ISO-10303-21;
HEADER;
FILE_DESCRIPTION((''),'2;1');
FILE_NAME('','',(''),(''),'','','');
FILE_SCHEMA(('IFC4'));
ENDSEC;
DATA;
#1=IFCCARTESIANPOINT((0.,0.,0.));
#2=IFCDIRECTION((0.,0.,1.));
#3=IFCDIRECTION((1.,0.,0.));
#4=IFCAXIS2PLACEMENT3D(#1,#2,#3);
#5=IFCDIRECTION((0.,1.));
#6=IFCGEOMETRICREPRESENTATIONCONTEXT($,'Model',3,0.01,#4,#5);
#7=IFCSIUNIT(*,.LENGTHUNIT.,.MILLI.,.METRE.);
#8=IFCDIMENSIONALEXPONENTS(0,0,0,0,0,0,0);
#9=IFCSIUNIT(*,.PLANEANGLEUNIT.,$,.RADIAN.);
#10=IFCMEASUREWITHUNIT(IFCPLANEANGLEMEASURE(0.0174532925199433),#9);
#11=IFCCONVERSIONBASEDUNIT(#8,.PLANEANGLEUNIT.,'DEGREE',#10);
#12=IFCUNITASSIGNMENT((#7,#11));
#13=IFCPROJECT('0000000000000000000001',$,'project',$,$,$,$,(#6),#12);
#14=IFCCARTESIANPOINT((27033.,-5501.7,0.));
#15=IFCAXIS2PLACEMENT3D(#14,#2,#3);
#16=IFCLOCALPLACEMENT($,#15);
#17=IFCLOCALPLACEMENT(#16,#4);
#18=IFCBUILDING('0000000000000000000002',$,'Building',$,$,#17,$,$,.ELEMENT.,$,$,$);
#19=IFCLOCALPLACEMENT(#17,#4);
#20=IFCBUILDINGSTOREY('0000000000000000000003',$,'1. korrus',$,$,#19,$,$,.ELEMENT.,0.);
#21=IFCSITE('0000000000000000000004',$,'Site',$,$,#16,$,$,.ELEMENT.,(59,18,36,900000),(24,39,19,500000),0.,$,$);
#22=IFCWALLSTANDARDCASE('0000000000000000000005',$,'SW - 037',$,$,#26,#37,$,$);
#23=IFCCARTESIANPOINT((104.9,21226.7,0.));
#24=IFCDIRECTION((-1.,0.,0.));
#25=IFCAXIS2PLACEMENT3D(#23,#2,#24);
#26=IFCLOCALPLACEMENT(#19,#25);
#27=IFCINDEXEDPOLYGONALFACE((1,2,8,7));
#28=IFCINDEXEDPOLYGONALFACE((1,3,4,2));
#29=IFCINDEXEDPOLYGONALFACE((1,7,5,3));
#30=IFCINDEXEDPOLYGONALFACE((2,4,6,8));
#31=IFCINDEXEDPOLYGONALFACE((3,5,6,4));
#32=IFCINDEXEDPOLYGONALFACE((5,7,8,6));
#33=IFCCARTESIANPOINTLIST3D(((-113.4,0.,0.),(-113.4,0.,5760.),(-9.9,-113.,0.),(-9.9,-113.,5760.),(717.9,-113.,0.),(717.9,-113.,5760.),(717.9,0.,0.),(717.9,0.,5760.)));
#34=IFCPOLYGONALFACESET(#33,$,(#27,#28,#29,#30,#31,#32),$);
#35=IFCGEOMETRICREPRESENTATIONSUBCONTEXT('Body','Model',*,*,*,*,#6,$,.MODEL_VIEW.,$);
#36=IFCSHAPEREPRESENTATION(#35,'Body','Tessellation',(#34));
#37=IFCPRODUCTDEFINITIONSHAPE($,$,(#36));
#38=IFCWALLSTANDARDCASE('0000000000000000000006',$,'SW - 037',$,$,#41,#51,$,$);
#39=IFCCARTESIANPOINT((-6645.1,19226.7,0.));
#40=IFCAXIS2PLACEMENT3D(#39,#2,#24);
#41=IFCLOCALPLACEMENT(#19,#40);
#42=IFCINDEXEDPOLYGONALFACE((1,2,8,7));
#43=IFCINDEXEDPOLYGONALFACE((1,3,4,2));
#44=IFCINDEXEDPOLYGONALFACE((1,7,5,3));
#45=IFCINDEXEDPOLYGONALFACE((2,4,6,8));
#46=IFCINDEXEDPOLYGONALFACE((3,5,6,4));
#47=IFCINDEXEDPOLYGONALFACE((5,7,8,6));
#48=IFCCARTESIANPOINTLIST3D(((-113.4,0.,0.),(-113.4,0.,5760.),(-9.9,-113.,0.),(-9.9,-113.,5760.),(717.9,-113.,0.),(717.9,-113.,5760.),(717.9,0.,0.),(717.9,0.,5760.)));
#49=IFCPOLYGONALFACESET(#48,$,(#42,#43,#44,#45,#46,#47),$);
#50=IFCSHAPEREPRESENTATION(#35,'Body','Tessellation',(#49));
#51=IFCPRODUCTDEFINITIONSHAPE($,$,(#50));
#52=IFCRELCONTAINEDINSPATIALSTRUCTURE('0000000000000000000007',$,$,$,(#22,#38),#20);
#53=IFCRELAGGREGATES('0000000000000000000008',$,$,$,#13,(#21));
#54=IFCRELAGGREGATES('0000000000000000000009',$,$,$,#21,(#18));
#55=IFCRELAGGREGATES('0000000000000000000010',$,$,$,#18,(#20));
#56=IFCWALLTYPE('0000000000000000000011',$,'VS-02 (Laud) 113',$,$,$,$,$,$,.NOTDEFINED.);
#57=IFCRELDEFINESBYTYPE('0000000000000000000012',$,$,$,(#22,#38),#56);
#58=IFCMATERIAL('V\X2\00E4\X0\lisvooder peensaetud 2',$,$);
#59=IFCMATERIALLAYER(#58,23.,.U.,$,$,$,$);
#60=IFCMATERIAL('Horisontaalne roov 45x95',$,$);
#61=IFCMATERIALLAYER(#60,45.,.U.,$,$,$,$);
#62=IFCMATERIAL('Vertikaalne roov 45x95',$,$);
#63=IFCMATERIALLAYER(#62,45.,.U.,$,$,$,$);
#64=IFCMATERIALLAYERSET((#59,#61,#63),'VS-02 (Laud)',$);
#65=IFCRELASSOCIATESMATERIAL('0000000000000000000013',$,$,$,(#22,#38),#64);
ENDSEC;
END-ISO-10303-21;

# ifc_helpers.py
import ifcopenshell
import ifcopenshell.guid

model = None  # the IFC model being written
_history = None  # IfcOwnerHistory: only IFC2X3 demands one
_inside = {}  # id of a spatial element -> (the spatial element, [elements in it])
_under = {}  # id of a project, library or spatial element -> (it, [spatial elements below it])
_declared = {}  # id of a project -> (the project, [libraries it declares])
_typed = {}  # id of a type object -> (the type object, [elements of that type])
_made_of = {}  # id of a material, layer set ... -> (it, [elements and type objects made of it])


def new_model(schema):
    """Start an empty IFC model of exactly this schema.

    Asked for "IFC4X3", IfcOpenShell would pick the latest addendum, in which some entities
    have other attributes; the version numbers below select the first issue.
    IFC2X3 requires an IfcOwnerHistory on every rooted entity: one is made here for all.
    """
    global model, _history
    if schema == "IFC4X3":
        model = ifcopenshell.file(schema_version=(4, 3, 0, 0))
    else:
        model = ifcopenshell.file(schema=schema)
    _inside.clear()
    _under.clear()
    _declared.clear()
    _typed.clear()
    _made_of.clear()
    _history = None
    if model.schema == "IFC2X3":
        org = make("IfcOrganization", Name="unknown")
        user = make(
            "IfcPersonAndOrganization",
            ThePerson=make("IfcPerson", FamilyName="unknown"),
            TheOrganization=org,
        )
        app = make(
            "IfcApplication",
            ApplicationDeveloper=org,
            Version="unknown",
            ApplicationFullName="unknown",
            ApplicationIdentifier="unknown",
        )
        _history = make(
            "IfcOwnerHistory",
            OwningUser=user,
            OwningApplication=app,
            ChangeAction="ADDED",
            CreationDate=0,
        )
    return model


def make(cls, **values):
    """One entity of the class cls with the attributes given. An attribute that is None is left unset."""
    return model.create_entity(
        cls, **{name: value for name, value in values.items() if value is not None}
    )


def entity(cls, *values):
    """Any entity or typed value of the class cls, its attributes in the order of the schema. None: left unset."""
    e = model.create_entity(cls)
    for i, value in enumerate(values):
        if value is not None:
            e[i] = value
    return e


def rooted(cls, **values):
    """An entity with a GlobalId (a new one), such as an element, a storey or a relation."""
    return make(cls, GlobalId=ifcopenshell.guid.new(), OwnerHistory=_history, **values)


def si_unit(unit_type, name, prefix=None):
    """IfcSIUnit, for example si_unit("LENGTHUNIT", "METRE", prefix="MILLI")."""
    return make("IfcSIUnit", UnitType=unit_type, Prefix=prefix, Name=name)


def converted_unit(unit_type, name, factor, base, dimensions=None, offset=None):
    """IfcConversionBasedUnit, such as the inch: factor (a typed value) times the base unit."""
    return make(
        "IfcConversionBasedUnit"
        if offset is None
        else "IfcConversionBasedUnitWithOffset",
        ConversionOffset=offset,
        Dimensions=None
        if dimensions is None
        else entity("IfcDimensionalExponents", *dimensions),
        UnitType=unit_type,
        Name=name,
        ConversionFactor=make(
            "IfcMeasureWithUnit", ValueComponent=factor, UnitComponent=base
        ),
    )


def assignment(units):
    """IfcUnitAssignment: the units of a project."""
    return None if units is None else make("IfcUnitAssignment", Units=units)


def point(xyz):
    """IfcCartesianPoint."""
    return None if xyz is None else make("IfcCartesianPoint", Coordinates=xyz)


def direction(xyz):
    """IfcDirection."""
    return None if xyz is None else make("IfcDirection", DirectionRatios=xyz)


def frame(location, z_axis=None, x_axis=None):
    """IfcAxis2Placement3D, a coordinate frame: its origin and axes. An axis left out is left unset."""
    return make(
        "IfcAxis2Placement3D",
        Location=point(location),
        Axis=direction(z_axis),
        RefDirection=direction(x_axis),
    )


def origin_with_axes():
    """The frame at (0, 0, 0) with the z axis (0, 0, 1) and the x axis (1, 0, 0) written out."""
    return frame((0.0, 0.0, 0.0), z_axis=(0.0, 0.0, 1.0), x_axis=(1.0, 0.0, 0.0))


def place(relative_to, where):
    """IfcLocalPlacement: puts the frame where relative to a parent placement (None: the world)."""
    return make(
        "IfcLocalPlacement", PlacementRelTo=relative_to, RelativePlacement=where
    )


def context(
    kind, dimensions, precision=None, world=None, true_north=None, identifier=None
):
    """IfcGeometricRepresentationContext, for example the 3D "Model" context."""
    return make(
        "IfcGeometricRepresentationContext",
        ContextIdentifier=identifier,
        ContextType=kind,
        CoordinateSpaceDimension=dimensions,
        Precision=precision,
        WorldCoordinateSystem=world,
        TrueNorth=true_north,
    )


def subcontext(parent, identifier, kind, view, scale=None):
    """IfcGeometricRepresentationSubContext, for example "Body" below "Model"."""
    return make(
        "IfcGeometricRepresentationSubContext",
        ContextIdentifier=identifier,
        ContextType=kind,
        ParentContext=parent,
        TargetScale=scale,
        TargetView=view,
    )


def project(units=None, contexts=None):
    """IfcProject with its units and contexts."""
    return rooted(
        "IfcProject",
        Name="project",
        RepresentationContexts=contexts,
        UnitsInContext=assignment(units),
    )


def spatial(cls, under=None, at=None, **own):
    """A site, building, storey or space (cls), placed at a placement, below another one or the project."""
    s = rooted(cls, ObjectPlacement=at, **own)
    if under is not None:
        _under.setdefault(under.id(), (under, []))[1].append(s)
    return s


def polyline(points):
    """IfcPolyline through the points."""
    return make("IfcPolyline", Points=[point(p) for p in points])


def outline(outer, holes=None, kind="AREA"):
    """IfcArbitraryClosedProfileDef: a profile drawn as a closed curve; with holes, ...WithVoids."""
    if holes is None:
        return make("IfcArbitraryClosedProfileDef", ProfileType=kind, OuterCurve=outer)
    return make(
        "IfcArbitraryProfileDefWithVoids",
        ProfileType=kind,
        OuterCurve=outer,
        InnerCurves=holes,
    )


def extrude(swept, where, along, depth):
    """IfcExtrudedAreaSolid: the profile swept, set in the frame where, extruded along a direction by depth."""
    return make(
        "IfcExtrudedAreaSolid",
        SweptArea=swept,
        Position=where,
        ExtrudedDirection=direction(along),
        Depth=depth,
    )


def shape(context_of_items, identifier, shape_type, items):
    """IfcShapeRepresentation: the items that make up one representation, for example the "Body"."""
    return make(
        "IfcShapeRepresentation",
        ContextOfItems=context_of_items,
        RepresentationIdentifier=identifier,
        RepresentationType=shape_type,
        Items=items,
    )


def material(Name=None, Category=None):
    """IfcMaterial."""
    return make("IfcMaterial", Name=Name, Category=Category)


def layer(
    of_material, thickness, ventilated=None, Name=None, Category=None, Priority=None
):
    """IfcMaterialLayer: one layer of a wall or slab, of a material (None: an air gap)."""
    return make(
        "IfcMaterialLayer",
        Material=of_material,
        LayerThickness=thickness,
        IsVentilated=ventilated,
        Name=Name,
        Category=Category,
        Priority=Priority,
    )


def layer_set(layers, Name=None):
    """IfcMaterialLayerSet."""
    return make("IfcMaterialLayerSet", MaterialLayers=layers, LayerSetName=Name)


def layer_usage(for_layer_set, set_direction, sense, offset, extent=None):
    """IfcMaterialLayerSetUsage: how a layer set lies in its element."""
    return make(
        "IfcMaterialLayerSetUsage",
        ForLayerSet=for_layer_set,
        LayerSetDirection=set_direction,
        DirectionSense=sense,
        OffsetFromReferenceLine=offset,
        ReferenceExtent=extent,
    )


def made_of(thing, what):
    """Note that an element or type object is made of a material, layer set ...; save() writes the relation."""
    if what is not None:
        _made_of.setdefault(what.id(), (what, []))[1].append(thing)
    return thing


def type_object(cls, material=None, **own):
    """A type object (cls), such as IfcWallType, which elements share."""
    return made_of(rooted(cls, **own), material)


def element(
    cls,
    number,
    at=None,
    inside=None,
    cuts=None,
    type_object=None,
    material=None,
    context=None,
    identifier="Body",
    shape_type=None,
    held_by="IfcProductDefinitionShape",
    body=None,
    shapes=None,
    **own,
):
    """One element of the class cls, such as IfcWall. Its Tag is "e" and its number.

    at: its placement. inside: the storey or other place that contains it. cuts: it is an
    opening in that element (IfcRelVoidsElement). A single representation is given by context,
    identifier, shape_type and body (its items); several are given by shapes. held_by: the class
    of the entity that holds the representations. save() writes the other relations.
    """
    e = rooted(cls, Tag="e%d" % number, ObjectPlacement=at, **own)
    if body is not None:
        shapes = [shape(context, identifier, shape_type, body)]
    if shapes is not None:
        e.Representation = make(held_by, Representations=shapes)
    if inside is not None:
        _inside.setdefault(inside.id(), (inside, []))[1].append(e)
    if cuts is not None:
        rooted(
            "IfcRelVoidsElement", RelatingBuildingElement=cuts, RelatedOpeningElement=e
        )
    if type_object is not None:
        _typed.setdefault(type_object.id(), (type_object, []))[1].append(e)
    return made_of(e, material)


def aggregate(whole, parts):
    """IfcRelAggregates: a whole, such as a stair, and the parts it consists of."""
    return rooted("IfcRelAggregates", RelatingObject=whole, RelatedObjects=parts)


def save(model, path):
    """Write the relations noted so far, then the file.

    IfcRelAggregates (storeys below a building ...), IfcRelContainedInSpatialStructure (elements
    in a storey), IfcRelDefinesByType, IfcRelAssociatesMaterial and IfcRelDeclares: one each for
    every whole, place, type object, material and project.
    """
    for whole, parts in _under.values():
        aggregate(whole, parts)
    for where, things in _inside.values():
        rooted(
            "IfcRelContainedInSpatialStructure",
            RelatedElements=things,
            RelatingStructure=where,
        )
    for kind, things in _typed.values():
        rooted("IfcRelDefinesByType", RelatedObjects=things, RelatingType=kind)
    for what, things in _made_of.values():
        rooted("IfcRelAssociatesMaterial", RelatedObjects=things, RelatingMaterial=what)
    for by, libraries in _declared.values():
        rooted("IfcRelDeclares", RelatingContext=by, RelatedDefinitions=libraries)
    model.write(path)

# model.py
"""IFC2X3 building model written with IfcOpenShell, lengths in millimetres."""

from ifc_helpers import new_model, entity, si_unit, converted_unit, direction, frame, origin_with_axes, place, context, subcontext, project, spatial, polyline, outline, extrude, material, layer, layer_set, layer_usage, type_object, element, save


model = new_model("IFC2X3")

# Units and contexts
model_context = context("Model", 3, precision=0.01, world=origin_with_axes(), true_north=direction((0.0, 1.0)))
body_context = subcontext(model_context, "Body", "Model", "MODEL_VIEW")
ifc_project = project(units=[si_unit("LENGTHUNIT", "METRE", prefix="MILLI"), converted_unit("PLANEANGLEUNIT", "DEGREE", entity("IfcPlaneAngleMeasure", 0.0174532925199433), si_unit("PLANEANGLEUNIT", "RADIAN"), dimensions=[0, 0, 0, 0, 0, 0, 0])], contexts=[model_context])

# Site, building, storey
site_placement = place(None, frame((27033.0, -5501.7, 0.0), z_axis=(0.0, 0.0, 1.0), x_axis=(1.0, 0.0, 0.0)))
site = spatial("IfcSite", under=ifc_project, at=site_placement, Name="Site", CompositionType="ELEMENT", RefLatitude=(59, 18, 36, 900000), RefLongitude=(24, 39, 19, 500000), RefElevation=0.0)
building_placement = place(site_placement, origin_with_axes())
building = spatial("IfcBuilding", under=site, at=building_placement, Name="Building", CompositionType="ELEMENT")
storey_placement = place(building_placement, origin_with_axes())
storey = spatial("IfcBuildingStorey", under=building, at=storey_placement, Name="1. korrus", CompositionType="ELEMENT", Elevation=0.0)

# Walls
ifc_material_1 = material(Name="Välisvooder peensaetud 2")
ifc_layer_1 = layer(ifc_material_1, 23.0, ventilated="UNKNOWN")
ifc_material_2 = material(Name="Horisontaalne roov 45x95")
ifc_layer_2 = layer(ifc_material_2, 45.0, ventilated="UNKNOWN")
ifc_material_3 = material(Name="Vertikaalne roov 45x95")
ifc_layer_3 = layer(ifc_material_3, 45.0, ventilated="UNKNOWN")
ifc_layer_set_1 = layer_set([ifc_layer_1, ifc_layer_2, ifc_layer_3], Name="VS-02 (Laud)")
wall_type_1 = type_object("IfcWallType", Name="VS-02 (Laud) 113", PredefinedType="NOTDEFINED")
ifc_layer_usage_1 = layer_usage(ifc_layer_set_1, "AXIS2", "POSITIVE", -113.0)
wall_1_placement = place(storey_placement, frame((104.9, 21226.7, 0.0), z_axis=(0.0, 0.0, 1.0), x_axis=(-1.0, 0.0, 0.0)))
element("IfcWallStandardCase", 1, at=wall_1_placement, inside=storey, type_object=wall_type_1, material=ifc_layer_usage_1, Name="SW - 037", context=body_context, shape_type="SweptSolid", body=[
    extrude(outline(polyline([(-9.9, -113.0), (717.9, -113.0), (717.9, 0.0), (-113.4, 0.0), (-9.9, -113.0)])), origin_with_axes(), (0.0, 0.0, 1.0), 5760.0),
])
ifc_layer_usage_2 = layer_usage(ifc_layer_set_1, "AXIS2", "POSITIVE", -113.0)
wall_2_placement = place(storey_placement, frame((-6645.1, 19226.7, 0.0), z_axis=(0.0, 0.0, 1.0), x_axis=(-1.0, 0.0, 0.0)))
element("IfcWallStandardCase", 2, at=wall_2_placement, inside=storey, type_object=wall_type_1, material=ifc_layer_usage_2, Name="SW - 037", context=body_context, shape_type="SweptSolid", body=[
    extrude(outline(polyline([(-9.9, -113.0), (717.9, -113.0), (717.9, 0.0), (-113.4, 0.0), (-9.9, -113.0)])), origin_with_axes(), (0.0, 0.0, 1.0), 5760.0),
])

save(model, "model.ifc")
